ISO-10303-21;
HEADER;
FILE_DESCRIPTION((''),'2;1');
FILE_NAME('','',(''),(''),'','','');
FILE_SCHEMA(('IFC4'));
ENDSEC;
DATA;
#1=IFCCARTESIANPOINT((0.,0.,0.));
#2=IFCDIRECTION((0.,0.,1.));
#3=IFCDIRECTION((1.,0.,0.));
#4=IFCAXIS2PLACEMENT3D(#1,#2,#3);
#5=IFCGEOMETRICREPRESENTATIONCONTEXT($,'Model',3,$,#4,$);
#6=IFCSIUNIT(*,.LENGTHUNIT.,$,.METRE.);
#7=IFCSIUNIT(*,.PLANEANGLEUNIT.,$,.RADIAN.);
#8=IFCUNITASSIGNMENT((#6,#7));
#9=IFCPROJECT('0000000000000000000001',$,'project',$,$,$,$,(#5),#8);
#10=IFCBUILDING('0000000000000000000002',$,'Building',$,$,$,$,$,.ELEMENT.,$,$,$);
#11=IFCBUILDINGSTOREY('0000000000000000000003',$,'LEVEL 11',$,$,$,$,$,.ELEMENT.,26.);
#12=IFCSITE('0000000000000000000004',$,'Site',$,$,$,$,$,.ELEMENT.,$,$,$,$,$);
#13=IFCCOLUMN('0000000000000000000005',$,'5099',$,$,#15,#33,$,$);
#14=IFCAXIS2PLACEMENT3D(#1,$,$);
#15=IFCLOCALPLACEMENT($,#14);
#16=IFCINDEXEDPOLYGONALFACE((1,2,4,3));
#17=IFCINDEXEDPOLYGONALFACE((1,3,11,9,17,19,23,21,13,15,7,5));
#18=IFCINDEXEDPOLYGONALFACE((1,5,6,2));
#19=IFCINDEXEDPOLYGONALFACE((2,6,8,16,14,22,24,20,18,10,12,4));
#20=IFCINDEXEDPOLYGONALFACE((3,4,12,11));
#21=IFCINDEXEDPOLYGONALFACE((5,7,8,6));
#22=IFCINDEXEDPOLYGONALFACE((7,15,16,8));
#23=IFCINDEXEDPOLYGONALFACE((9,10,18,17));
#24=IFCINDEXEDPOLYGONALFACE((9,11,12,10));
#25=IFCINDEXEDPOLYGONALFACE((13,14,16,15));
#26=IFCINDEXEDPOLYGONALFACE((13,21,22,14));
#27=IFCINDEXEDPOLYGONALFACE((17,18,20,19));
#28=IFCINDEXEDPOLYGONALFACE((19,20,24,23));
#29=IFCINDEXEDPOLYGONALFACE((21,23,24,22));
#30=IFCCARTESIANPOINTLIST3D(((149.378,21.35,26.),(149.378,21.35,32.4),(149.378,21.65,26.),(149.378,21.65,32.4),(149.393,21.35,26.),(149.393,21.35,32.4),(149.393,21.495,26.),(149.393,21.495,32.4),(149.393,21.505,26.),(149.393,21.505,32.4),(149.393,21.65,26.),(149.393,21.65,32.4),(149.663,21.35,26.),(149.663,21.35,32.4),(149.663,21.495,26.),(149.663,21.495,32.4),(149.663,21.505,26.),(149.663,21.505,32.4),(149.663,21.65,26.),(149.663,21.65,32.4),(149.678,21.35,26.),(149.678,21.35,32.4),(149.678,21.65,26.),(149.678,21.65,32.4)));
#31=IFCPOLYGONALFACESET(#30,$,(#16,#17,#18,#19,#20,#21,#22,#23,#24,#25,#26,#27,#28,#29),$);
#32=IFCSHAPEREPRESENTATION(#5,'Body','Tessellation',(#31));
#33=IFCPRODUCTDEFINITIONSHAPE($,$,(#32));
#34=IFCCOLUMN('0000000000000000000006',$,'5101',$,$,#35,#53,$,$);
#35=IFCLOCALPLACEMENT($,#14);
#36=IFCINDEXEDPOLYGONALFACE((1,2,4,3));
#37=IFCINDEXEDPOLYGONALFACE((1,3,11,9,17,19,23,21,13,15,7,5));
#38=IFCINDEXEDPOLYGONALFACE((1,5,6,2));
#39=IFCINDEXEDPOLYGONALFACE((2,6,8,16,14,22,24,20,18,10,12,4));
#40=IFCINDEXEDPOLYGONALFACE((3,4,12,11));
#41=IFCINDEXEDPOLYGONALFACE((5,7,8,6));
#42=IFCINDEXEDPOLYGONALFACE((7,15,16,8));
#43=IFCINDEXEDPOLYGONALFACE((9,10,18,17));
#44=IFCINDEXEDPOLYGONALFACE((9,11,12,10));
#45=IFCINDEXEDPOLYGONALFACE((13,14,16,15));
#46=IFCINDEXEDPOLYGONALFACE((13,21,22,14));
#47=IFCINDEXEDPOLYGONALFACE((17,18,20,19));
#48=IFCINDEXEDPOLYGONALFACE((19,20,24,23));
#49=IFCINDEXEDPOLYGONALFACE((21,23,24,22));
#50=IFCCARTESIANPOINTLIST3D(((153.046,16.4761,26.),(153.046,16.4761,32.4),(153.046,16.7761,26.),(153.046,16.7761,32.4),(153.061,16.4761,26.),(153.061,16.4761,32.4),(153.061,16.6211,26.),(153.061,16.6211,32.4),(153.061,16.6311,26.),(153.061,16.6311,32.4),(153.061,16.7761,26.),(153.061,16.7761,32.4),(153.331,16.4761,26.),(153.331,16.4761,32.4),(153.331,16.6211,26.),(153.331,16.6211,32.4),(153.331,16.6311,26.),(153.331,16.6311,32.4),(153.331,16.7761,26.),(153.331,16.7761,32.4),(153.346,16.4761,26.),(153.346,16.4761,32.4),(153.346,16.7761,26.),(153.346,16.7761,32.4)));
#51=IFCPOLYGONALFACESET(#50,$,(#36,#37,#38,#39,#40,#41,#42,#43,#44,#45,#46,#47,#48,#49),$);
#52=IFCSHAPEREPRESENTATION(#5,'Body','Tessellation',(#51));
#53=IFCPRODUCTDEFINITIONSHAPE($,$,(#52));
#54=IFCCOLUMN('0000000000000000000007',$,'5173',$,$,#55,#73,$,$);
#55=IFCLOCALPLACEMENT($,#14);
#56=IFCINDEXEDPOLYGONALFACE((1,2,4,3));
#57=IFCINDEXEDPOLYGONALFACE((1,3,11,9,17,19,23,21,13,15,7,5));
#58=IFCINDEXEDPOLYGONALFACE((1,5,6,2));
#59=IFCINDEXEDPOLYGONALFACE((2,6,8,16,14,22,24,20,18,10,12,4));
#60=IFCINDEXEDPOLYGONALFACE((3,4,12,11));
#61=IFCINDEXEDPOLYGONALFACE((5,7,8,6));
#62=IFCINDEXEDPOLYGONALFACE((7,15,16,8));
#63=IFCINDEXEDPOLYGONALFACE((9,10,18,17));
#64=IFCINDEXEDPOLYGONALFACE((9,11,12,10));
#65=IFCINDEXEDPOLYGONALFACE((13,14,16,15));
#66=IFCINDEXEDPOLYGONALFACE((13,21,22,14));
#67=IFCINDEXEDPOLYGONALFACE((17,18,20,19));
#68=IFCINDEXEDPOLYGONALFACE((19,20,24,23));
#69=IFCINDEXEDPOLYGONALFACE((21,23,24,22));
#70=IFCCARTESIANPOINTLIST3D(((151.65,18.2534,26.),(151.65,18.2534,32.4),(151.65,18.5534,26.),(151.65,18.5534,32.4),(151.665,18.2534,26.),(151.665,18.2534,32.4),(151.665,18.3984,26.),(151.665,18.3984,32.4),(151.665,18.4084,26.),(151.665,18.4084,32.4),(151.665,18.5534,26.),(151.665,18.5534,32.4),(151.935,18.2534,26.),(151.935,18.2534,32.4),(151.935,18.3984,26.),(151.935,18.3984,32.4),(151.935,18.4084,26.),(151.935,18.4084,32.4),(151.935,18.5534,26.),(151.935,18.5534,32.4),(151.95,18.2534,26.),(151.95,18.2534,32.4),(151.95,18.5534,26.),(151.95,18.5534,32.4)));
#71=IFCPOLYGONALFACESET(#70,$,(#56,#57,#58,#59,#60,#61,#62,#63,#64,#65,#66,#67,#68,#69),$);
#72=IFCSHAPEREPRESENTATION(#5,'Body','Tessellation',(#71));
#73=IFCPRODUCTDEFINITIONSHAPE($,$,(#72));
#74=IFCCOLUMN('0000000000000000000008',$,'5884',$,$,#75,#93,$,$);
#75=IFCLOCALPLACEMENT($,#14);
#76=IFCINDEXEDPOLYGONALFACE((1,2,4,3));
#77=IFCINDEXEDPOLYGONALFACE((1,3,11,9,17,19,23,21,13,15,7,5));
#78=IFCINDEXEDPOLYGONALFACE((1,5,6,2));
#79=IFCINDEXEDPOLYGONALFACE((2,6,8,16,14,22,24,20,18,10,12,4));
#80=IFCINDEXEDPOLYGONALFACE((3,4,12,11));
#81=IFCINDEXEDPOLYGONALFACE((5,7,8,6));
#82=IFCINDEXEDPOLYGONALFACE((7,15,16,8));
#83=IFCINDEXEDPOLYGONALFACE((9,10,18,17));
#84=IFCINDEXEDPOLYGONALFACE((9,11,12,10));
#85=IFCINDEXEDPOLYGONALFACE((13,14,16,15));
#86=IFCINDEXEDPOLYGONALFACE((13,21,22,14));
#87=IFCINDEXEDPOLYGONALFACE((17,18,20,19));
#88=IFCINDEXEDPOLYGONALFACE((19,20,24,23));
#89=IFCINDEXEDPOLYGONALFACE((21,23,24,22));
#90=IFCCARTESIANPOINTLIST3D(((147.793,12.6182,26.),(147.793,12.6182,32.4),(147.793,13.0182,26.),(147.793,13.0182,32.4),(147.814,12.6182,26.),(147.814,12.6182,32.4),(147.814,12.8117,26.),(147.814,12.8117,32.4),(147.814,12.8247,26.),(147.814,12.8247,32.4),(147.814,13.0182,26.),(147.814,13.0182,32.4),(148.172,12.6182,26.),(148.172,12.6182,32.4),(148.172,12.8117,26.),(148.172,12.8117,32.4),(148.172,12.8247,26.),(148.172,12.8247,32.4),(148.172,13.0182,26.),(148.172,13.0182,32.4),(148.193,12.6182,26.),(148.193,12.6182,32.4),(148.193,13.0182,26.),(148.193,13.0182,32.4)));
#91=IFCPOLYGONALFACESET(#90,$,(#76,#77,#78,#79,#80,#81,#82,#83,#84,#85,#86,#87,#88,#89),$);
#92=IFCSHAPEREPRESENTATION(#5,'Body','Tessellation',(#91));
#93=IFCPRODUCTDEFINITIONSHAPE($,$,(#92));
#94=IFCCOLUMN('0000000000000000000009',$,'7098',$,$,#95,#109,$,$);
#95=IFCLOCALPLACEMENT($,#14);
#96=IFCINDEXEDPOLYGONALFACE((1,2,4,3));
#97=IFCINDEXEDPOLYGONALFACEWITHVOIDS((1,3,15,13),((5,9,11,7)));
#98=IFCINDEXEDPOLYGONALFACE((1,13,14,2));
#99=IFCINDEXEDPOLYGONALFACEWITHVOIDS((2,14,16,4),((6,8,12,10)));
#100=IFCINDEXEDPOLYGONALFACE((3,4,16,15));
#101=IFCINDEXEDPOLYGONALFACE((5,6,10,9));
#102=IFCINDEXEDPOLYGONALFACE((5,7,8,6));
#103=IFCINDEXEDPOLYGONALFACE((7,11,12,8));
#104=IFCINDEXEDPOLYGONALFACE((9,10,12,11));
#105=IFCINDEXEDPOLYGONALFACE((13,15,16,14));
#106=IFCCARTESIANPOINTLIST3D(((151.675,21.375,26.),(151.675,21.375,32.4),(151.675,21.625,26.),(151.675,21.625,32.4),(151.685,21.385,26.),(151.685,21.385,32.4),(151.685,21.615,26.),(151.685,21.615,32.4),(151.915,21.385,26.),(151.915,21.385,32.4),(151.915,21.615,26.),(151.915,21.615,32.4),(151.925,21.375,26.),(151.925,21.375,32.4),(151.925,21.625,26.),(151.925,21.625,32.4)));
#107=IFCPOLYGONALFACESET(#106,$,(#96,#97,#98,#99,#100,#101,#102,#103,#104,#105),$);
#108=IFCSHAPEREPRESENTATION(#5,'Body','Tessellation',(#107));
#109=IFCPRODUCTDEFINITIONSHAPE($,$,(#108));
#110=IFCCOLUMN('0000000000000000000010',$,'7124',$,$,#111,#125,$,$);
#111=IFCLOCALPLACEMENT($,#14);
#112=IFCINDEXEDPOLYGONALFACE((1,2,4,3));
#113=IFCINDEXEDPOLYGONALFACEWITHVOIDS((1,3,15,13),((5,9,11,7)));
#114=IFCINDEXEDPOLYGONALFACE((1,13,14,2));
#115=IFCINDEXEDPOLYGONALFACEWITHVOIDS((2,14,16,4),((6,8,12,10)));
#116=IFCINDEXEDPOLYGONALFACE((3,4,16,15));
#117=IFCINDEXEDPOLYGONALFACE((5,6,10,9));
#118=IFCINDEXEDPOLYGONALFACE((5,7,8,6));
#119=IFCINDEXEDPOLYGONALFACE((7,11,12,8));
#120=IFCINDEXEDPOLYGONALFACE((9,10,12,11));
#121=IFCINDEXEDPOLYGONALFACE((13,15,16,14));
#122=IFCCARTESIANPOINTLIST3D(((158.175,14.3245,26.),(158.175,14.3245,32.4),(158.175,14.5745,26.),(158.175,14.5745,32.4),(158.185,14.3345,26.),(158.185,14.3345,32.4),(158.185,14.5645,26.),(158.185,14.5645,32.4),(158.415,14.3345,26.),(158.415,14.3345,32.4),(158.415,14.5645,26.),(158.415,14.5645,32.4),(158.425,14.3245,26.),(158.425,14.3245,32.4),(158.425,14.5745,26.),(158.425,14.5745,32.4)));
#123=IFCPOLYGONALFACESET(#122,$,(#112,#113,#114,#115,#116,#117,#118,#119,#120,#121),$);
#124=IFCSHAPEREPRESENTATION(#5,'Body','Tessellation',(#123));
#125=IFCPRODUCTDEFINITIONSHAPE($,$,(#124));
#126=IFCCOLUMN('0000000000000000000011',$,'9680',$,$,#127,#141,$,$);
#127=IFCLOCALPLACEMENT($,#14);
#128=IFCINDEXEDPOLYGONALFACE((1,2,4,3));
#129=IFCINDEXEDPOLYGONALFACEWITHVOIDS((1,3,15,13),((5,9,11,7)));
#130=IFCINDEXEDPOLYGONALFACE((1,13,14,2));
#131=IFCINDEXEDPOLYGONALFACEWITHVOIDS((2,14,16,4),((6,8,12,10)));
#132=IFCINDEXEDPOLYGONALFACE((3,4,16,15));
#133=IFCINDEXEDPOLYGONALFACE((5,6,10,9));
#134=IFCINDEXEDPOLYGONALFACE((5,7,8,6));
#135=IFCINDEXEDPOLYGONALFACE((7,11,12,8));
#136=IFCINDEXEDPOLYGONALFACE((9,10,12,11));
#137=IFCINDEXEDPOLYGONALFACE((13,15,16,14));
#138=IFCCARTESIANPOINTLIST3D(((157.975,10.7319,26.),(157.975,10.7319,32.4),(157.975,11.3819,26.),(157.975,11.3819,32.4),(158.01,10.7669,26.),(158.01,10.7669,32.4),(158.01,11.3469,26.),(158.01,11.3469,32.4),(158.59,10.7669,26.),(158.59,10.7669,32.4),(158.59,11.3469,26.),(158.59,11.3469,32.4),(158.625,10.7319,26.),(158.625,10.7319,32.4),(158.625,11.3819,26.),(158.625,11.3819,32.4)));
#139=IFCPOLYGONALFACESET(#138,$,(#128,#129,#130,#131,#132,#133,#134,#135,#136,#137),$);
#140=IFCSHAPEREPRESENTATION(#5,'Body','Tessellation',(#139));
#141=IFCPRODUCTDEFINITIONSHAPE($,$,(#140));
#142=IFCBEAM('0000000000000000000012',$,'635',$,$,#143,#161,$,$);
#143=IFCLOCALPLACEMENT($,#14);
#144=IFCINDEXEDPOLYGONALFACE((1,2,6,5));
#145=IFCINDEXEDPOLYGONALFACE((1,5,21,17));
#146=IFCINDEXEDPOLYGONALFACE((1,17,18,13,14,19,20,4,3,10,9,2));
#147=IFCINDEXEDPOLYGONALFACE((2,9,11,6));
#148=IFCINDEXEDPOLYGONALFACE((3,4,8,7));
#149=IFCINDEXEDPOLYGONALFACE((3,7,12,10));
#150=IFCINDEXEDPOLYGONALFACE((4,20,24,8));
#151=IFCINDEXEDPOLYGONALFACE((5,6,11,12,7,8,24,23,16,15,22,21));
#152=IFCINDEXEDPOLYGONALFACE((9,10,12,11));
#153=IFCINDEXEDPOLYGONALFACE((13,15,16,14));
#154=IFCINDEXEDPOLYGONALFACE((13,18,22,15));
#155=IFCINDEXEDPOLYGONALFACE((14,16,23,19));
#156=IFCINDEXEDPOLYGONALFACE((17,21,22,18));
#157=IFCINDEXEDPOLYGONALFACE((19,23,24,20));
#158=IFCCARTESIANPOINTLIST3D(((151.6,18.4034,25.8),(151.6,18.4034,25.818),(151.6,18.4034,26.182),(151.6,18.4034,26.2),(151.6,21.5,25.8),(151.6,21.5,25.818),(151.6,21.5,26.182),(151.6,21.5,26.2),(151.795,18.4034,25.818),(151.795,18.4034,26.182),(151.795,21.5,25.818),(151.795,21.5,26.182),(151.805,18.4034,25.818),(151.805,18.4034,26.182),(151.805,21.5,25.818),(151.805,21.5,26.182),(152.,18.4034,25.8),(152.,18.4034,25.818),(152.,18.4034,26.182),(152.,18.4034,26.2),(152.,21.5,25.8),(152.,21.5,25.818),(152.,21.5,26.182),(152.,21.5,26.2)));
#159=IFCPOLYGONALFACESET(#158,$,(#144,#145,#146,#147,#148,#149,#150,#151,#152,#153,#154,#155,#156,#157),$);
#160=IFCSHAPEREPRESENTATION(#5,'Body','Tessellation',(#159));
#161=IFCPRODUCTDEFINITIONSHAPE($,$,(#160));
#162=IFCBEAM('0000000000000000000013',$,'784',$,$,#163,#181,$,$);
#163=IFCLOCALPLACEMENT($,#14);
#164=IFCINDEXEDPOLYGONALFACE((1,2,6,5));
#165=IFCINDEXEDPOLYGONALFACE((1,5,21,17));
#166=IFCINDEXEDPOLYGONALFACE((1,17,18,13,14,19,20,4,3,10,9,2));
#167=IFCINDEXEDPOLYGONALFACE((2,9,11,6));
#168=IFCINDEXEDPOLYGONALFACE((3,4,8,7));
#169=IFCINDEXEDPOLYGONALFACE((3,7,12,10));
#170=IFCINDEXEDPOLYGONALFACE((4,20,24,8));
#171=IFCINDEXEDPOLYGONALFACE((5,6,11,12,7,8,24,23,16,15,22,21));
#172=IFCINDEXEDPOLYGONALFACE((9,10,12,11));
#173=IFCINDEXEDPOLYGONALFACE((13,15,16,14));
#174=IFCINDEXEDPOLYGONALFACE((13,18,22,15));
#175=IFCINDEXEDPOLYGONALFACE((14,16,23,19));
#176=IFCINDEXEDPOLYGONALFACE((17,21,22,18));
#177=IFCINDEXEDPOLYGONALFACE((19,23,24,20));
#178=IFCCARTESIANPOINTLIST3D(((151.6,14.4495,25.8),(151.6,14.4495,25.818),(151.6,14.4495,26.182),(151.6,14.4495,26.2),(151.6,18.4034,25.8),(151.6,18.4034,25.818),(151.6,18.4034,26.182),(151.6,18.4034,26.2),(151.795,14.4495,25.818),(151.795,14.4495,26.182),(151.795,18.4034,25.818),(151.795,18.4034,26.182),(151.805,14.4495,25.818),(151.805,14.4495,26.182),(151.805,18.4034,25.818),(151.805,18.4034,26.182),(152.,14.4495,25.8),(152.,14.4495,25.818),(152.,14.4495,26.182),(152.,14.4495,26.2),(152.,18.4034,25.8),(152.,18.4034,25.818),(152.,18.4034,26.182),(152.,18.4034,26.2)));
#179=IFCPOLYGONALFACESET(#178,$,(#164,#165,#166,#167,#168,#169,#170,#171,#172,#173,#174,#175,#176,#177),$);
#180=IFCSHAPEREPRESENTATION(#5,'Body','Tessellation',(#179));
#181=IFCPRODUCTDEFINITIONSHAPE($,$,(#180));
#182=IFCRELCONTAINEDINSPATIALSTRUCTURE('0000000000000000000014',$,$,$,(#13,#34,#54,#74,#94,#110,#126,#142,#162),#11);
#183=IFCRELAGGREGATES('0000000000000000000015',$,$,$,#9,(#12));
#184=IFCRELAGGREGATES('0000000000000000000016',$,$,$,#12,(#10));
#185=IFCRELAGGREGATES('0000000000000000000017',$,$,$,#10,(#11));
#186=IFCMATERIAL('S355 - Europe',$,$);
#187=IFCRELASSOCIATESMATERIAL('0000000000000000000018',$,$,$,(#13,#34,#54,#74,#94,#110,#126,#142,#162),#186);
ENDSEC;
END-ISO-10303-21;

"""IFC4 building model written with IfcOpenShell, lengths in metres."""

from ifc_helpers import new_model, si_unit, frame, origin_with_axes, origin_2d_with_axis, place, context, project, spatial, hollow_rectangle, i_section, extrude, material, material_profile, profile_set, profile_usage, element, save


model = new_model("IFC4")

# Units and contexts
model_context = context("Model", 3, world=origin_with_axes())
ifc_project = project(units=[si_unit("LENGTHUNIT", "METRE"), si_unit("PLANEANGLEUNIT", "RADIAN")], contexts=[model_context])

# Site, building, storey
site = spatial("IfcSite", under=ifc_project, Name="Site", CompositionType="ELEMENT")
building = spatial("IfcBuilding", under=site, Name="Building", CompositionType="ELEMENT")
storey = spatial("IfcBuildingStorey", under=building, Name="LEVEL 11", CompositionType="ELEMENT", Elevation=26.0)

# Columns
ifc_material = material(Name="S355 - Europe")
ifc_material_profile_1 = material_profile(ifc_material, i_section(OverallWidth=0.3, OverallDepth=0.3, WebThickness=0.01, FlangeThickness=0.015, at=origin_2d_with_axis()))
ifc_profile_set_1 = profile_set([ifc_material_profile_1])
ifc_profile_usage_1 = profile_usage(ifc_profile_set_1, cardinal=10)
column_1_placement = place(None, frame((149.528, 21.5, 26.0), z_axis=(0.0, 0.0, 1.0), x_axis=(0.0, -1.0, 0.0)))
element("IfcColumn", 1, at=column_1_placement, inside=storey, material=ifc_profile_usage_1, Name="5099", context=model_context, shape_type="SweptSolid", body=[
    extrude(i_section(OverallWidth=0.3, OverallDepth=0.3, WebThickness=0.01, FlangeThickness=0.015, at=origin_2d_with_axis()), origin_with_axes(), (0.0, 0.0, 1.0), 6.4),
])
ifc_material_profile_2 = material_profile(ifc_material, i_section(OverallWidth=0.3, OverallDepth=0.3, WebThickness=0.01, FlangeThickness=0.015, at=origin_2d_with_axis()))
ifc_profile_set_2 = profile_set([ifc_material_profile_2])
ifc_profile_usage_2 = profile_usage(ifc_profile_set_2, cardinal=10)
column_2_placement = place(None, frame((153.196, 16.6261, 26.0), z_axis=(0.0, 0.0, 1.0), x_axis=(0.0, -1.0, 0.0)))
element("IfcColumn", 2, at=column_2_placement, inside=storey, material=ifc_profile_usage_2, Name="5101", context=model_context, shape_type="SweptSolid", body=[
    extrude(i_section(OverallWidth=0.3, OverallDepth=0.3, WebThickness=0.01, FlangeThickness=0.015, at=origin_2d_with_axis()), origin_with_axes(), (0.0, 0.0, 1.0), 6.4),
])
ifc_material_profile_3 = material_profile(ifc_material, i_section(OverallWidth=0.3, OverallDepth=0.3, WebThickness=0.01, FlangeThickness=0.015, at=origin_2d_with_axis()))
ifc_profile_set_3 = profile_set([ifc_material_profile_3])
ifc_profile_usage_3 = profile_usage(ifc_profile_set_3, cardinal=10)
column_3_placement = place(None, frame((151.8, 18.4034, 26.0), z_axis=(0.0, 0.0, 1.0), x_axis=(0.0, -1.0, 0.0)))
element("IfcColumn", 3, at=column_3_placement, inside=storey, material=ifc_profile_usage_3, Name="5173", context=model_context, shape_type="SweptSolid", body=[
    extrude(i_section(OverallWidth=0.3, OverallDepth=0.3, WebThickness=0.01, FlangeThickness=0.015, at=origin_2d_with_axis()), origin_with_axes(), (0.0, 0.0, 1.0), 6.4),
])
ifc_material_profile_4 = material_profile(ifc_material, i_section(OverallWidth=0.4, OverallDepth=0.4, WebThickness=0.013, FlangeThickness=0.021, at=origin_2d_with_axis()))
ifc_profile_set_4 = profile_set([ifc_material_profile_4])
ifc_profile_usage_4 = profile_usage(ifc_profile_set_4, cardinal=10)
column_4_placement = place(None, frame((147.993, 12.8182, 26.0), z_axis=(0.0, 0.0, 1.0), x_axis=(0.0, -1.0, 0.0)))
element("IfcColumn", 4, at=column_4_placement, inside=storey, material=ifc_profile_usage_4, Name="5884", context=model_context, shape_type="SweptSolid", body=[
    extrude(i_section(OverallWidth=0.4, OverallDepth=0.4, WebThickness=0.013, FlangeThickness=0.021, at=origin_2d_with_axis()), origin_with_axes(), (0.0, 0.0, 1.0), 6.4),
])
ifc_material_profile_5 = material_profile(ifc_material, hollow_rectangle(XDim=0.25, YDim=0.25, WallThickness=0.01, at=origin_2d_with_axis()))
ifc_profile_set_5 = profile_set([ifc_material_profile_5])
ifc_profile_usage_5 = profile_usage(ifc_profile_set_5, cardinal=10)
column_5_placement = place(None, frame((151.8, 21.5, 26.0), z_axis=(0.0, 0.0, 1.0), x_axis=(0.0, -1.0, 0.0)))
element("IfcColumn", 5, at=column_5_placement, inside=storey, material=ifc_profile_usage_5, Name="7098", context=model_context, shape_type="SweptSolid", body=[
    extrude(hollow_rectangle(XDim=0.25, YDim=0.25, WallThickness=0.01, at=origin_2d_with_axis()), origin_with_axes(), (0.0, 0.0, 1.0), 6.4),
])
ifc_material_profile_6 = material_profile(ifc_material, hollow_rectangle(XDim=0.25, YDim=0.25, WallThickness=0.01, at=origin_2d_with_axis()))
ifc_profile_set_6 = profile_set([ifc_material_profile_6])
ifc_profile_usage_6 = profile_usage(ifc_profile_set_6, cardinal=10)
column_6_placement = place(None, frame((158.3, 14.4495, 26.0), z_axis=(0.0, 0.0, 1.0), x_axis=(0.0, -1.0, 0.0)))
element("IfcColumn", 6, at=column_6_placement, inside=storey, material=ifc_profile_usage_6, Name="7124", context=model_context, shape_type="SweptSolid", body=[
    extrude(hollow_rectangle(XDim=0.25, YDim=0.25, WallThickness=0.01, at=origin_2d_with_axis()), origin_with_axes(), (0.0, 0.0, 1.0), 6.4),
])
ifc_material_profile_7 = material_profile(ifc_material, hollow_rectangle(XDim=0.65, YDim=0.65, WallThickness=0.035, at=origin_2d_with_axis()))
ifc_profile_set_7 = profile_set([ifc_material_profile_7])
ifc_profile_usage_7 = profile_usage(ifc_profile_set_7, cardinal=10)
column_7_placement = place(None, frame((158.3, 11.0569, 26.0), z_axis=(0.0, 0.0, 1.0), x_axis=(0.0, -1.0, 0.0)))
element("IfcColumn", 7, at=column_7_placement, inside=storey, material=ifc_profile_usage_7, Name="9680", context=model_context, shape_type="SweptSolid", body=[
    extrude(hollow_rectangle(XDim=0.65, YDim=0.65, WallThickness=0.035, at=origin_2d_with_axis()), origin_with_axes(), (0.0, 0.0, 1.0), 6.4),
])

# Beams
ifc_material_profile_8 = material_profile(ifc_material, i_section(OverallWidth=0.4, OverallDepth=0.4, WebThickness=0.01, FlangeThickness=0.018, at=origin_2d_with_axis()))
ifc_profile_set_8 = profile_set([ifc_material_profile_8])
ifc_profile_usage_8 = profile_usage(ifc_profile_set_8, cardinal=10)
beam_1_placement = place(None, frame((151.8, 21.5, 26.0), z_axis=(0.0, -1.0, 0.0), x_axis=(1.0, 0.0, 0.0)))
element("IfcBeam", 8, at=beam_1_placement, inside=storey, material=ifc_profile_usage_8, Name="635", context=model_context, shape_type="SweptSolid", body=[
    extrude(i_section(OverallWidth=0.4, OverallDepth=0.4, WebThickness=0.01, FlangeThickness=0.018, at=origin_2d_with_axis()), origin_with_axes(), (0.0, 0.0, 1.0), 3.0966),
])
ifc_material_profile_9 = material_profile(ifc_material, i_section(OverallWidth=0.4, OverallDepth=0.4, WebThickness=0.01, FlangeThickness=0.018, at=origin_2d_with_axis()))
ifc_profile_set_9 = profile_set([ifc_material_profile_9])
ifc_profile_usage_9 = profile_usage(ifc_profile_set_9, cardinal=10)
beam_2_placement = place(None, frame((151.8, 18.4034, 26.0), z_axis=(0.0, -1.0, 0.0), x_axis=(1.0, 0.0, 0.0)))
element("IfcBeam", 9, at=beam_2_placement, inside=storey, material=ifc_profile_usage_9, Name="784", context=model_context, shape_type="SweptSolid", body=[
    extrude(i_section(OverallWidth=0.4, OverallDepth=0.4, WebThickness=0.01, FlangeThickness=0.018, at=origin_2d_with_axis()), origin_with_axes(), (0.0, 0.0, 1.0), 3.9539),
])

save(model, "model.ifc")
